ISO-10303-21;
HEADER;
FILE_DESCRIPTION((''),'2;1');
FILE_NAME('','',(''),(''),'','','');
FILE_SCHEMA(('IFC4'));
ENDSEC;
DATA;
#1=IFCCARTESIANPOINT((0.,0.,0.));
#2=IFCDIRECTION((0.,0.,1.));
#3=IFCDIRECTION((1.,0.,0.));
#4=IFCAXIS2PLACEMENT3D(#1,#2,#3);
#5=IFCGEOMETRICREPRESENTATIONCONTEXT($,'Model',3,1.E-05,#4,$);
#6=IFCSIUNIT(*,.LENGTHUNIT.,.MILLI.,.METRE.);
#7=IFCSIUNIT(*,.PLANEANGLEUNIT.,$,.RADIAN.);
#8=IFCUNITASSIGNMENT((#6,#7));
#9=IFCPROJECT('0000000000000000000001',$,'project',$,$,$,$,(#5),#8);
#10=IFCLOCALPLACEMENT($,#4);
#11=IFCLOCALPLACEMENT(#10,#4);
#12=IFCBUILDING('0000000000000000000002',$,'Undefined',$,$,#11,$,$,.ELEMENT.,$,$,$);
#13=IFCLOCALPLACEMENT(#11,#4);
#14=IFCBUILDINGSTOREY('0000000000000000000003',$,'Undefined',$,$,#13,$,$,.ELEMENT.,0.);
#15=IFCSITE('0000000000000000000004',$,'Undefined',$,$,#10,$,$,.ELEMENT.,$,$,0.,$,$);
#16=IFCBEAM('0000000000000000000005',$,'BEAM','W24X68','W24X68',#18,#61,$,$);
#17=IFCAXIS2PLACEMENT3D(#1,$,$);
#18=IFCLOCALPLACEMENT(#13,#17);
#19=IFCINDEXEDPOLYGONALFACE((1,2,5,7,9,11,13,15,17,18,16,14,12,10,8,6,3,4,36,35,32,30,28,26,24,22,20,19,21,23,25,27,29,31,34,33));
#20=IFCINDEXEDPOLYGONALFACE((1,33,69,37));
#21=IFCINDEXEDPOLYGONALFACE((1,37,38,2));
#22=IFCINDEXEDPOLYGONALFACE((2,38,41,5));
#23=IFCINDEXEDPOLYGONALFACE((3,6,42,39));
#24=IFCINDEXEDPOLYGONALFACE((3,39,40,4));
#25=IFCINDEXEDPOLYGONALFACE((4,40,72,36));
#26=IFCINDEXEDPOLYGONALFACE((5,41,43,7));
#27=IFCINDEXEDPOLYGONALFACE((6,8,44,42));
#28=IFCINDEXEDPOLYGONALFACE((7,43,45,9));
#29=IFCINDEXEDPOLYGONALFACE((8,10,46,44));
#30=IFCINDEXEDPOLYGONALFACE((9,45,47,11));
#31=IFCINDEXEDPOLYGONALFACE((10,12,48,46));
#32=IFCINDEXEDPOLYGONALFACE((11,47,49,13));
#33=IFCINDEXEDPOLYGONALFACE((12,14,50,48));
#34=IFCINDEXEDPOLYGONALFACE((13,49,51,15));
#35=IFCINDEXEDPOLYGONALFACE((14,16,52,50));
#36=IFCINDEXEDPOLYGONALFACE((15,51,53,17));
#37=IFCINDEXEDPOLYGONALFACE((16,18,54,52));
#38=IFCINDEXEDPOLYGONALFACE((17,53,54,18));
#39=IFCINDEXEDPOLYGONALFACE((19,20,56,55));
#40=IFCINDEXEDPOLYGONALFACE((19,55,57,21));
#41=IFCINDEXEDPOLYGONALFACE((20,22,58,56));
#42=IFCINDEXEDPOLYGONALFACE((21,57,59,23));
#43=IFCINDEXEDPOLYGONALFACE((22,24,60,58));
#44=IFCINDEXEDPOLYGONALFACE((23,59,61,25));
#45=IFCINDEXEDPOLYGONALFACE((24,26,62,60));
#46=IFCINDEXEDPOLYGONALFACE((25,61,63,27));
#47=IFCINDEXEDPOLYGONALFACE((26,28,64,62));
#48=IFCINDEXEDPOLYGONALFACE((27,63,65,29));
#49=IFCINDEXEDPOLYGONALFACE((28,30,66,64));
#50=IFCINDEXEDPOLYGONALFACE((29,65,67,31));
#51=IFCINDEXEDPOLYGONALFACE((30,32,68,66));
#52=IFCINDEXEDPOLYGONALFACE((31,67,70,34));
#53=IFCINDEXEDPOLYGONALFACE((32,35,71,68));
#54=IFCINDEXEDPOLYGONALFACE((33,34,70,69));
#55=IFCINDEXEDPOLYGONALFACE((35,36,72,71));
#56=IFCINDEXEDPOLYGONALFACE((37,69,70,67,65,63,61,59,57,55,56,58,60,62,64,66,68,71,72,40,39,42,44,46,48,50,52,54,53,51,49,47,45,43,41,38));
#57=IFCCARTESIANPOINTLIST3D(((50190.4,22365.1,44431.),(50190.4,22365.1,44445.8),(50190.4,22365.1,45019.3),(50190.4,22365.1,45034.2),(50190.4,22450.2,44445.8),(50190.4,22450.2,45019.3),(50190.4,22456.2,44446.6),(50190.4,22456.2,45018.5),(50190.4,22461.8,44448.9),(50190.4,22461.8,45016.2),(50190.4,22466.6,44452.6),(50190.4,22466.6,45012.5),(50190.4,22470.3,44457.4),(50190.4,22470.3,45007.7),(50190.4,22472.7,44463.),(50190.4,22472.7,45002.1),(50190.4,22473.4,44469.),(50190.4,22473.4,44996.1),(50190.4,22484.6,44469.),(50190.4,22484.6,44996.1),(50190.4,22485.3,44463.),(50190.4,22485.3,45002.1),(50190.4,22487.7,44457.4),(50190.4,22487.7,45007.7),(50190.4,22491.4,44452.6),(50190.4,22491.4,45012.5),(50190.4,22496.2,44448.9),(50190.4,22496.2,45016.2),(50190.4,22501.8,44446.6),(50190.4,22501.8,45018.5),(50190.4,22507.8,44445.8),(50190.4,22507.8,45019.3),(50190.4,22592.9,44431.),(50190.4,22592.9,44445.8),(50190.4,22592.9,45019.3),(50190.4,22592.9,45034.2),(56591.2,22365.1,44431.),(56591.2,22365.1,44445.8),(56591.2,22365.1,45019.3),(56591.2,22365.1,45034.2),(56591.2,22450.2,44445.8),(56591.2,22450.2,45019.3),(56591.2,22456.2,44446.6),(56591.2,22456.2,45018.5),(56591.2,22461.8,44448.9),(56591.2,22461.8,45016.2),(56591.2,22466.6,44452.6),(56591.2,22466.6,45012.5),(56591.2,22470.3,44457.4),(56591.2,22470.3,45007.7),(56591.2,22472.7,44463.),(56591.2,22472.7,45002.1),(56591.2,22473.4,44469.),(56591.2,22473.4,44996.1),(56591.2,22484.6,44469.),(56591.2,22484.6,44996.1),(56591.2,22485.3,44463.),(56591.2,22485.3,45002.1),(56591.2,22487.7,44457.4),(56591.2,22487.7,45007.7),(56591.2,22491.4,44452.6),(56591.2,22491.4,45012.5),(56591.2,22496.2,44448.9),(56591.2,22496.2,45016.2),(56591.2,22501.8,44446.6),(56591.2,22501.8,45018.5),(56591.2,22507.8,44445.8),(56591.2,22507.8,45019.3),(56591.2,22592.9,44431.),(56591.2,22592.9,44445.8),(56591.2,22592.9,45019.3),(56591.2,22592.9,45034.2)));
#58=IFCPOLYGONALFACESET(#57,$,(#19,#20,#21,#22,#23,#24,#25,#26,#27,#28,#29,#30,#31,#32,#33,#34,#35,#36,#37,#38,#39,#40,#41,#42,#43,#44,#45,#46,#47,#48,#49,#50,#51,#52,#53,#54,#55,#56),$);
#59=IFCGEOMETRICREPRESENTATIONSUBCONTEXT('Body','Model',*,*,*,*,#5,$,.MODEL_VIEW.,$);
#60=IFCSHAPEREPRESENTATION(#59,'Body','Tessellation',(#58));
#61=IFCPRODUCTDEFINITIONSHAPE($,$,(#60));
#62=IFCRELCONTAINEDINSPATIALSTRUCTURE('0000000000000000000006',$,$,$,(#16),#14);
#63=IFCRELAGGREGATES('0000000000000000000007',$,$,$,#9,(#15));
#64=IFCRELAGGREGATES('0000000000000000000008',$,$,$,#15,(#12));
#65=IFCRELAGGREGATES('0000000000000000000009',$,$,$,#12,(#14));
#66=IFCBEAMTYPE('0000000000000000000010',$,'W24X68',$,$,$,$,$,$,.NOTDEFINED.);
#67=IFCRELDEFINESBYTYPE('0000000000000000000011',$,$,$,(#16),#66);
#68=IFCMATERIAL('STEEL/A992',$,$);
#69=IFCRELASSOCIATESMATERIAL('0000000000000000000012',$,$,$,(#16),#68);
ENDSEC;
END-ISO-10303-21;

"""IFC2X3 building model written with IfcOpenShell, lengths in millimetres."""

from ifc_helpers import new_model, si_unit, frame, origin_with_axes, origin_2d_with_axis, place, context, subcontext, project, spatial, i_section, extrude, material, type_object, element, save


model = new_model("IFC2X3")

# Units and contexts
model_context = context("Model", 3, precision=1e-05, world=origin_with_axes())
body_context = subcontext(model_context, "Body", "Model", "MODEL_VIEW")
ifc_project = project(units=[si_unit("LENGTHUNIT", "METRE", prefix="MILLI"), si_unit("PLANEANGLEUNIT", "RADIAN")], contexts=[model_context])

# Site, building, storey
site_placement = place(None, origin_with_axes())
site = spatial("IfcSite", under=ifc_project, at=site_placement, Name="Undefined", CompositionType="ELEMENT", RefElevation=0.0)
building_placement = place(site_placement, origin_with_axes())
building = spatial("IfcBuilding", under=site, at=building_placement, Name="Undefined", CompositionType="ELEMENT")
storey_placement = place(building_placement, origin_with_axes())
storey = spatial("IfcBuildingStorey", under=building, at=storey_placement, Name="Undefined", CompositionType="ELEMENT", Elevation=0.0)

# Shared definitions
ifc_material = material(Name="STEEL/A992")

# Beam
beam_type = type_object("IfcBeamType", Name="W24X68", PredefinedType="NOTDEFINED")
beam_1_placement = place(storey_placement, frame((50190.4, 22479.0, 44732.6), z_axis=(0.0, 0.0, 1.0), x_axis=(1.0, 0.0, 0.0)))
element("IfcBeam", 1, at=beam_1_placement, inside=storey, type_object=beam_type, material=ifc_material, Name="BEAM", Description="W24X68", ObjectType="W24X68", context=body_context, shape_type="SweptSolid", body=[
    extrude(i_section(OverallWidth=227.8, OverallDepth=603.2, WebThickness=11.1, FlangeThickness=14.9, FilletRadius=23.2, at=origin_2d_with_axis()), frame((6400.8, 0.0, 0.0), z_axis=(-1.0, 0.0, 0.0), x_axis=(0.0, -1.0, 0.0)), (0.0, 0.0, 1.0), 6400.8),
])

save(model, "model.ifc")
